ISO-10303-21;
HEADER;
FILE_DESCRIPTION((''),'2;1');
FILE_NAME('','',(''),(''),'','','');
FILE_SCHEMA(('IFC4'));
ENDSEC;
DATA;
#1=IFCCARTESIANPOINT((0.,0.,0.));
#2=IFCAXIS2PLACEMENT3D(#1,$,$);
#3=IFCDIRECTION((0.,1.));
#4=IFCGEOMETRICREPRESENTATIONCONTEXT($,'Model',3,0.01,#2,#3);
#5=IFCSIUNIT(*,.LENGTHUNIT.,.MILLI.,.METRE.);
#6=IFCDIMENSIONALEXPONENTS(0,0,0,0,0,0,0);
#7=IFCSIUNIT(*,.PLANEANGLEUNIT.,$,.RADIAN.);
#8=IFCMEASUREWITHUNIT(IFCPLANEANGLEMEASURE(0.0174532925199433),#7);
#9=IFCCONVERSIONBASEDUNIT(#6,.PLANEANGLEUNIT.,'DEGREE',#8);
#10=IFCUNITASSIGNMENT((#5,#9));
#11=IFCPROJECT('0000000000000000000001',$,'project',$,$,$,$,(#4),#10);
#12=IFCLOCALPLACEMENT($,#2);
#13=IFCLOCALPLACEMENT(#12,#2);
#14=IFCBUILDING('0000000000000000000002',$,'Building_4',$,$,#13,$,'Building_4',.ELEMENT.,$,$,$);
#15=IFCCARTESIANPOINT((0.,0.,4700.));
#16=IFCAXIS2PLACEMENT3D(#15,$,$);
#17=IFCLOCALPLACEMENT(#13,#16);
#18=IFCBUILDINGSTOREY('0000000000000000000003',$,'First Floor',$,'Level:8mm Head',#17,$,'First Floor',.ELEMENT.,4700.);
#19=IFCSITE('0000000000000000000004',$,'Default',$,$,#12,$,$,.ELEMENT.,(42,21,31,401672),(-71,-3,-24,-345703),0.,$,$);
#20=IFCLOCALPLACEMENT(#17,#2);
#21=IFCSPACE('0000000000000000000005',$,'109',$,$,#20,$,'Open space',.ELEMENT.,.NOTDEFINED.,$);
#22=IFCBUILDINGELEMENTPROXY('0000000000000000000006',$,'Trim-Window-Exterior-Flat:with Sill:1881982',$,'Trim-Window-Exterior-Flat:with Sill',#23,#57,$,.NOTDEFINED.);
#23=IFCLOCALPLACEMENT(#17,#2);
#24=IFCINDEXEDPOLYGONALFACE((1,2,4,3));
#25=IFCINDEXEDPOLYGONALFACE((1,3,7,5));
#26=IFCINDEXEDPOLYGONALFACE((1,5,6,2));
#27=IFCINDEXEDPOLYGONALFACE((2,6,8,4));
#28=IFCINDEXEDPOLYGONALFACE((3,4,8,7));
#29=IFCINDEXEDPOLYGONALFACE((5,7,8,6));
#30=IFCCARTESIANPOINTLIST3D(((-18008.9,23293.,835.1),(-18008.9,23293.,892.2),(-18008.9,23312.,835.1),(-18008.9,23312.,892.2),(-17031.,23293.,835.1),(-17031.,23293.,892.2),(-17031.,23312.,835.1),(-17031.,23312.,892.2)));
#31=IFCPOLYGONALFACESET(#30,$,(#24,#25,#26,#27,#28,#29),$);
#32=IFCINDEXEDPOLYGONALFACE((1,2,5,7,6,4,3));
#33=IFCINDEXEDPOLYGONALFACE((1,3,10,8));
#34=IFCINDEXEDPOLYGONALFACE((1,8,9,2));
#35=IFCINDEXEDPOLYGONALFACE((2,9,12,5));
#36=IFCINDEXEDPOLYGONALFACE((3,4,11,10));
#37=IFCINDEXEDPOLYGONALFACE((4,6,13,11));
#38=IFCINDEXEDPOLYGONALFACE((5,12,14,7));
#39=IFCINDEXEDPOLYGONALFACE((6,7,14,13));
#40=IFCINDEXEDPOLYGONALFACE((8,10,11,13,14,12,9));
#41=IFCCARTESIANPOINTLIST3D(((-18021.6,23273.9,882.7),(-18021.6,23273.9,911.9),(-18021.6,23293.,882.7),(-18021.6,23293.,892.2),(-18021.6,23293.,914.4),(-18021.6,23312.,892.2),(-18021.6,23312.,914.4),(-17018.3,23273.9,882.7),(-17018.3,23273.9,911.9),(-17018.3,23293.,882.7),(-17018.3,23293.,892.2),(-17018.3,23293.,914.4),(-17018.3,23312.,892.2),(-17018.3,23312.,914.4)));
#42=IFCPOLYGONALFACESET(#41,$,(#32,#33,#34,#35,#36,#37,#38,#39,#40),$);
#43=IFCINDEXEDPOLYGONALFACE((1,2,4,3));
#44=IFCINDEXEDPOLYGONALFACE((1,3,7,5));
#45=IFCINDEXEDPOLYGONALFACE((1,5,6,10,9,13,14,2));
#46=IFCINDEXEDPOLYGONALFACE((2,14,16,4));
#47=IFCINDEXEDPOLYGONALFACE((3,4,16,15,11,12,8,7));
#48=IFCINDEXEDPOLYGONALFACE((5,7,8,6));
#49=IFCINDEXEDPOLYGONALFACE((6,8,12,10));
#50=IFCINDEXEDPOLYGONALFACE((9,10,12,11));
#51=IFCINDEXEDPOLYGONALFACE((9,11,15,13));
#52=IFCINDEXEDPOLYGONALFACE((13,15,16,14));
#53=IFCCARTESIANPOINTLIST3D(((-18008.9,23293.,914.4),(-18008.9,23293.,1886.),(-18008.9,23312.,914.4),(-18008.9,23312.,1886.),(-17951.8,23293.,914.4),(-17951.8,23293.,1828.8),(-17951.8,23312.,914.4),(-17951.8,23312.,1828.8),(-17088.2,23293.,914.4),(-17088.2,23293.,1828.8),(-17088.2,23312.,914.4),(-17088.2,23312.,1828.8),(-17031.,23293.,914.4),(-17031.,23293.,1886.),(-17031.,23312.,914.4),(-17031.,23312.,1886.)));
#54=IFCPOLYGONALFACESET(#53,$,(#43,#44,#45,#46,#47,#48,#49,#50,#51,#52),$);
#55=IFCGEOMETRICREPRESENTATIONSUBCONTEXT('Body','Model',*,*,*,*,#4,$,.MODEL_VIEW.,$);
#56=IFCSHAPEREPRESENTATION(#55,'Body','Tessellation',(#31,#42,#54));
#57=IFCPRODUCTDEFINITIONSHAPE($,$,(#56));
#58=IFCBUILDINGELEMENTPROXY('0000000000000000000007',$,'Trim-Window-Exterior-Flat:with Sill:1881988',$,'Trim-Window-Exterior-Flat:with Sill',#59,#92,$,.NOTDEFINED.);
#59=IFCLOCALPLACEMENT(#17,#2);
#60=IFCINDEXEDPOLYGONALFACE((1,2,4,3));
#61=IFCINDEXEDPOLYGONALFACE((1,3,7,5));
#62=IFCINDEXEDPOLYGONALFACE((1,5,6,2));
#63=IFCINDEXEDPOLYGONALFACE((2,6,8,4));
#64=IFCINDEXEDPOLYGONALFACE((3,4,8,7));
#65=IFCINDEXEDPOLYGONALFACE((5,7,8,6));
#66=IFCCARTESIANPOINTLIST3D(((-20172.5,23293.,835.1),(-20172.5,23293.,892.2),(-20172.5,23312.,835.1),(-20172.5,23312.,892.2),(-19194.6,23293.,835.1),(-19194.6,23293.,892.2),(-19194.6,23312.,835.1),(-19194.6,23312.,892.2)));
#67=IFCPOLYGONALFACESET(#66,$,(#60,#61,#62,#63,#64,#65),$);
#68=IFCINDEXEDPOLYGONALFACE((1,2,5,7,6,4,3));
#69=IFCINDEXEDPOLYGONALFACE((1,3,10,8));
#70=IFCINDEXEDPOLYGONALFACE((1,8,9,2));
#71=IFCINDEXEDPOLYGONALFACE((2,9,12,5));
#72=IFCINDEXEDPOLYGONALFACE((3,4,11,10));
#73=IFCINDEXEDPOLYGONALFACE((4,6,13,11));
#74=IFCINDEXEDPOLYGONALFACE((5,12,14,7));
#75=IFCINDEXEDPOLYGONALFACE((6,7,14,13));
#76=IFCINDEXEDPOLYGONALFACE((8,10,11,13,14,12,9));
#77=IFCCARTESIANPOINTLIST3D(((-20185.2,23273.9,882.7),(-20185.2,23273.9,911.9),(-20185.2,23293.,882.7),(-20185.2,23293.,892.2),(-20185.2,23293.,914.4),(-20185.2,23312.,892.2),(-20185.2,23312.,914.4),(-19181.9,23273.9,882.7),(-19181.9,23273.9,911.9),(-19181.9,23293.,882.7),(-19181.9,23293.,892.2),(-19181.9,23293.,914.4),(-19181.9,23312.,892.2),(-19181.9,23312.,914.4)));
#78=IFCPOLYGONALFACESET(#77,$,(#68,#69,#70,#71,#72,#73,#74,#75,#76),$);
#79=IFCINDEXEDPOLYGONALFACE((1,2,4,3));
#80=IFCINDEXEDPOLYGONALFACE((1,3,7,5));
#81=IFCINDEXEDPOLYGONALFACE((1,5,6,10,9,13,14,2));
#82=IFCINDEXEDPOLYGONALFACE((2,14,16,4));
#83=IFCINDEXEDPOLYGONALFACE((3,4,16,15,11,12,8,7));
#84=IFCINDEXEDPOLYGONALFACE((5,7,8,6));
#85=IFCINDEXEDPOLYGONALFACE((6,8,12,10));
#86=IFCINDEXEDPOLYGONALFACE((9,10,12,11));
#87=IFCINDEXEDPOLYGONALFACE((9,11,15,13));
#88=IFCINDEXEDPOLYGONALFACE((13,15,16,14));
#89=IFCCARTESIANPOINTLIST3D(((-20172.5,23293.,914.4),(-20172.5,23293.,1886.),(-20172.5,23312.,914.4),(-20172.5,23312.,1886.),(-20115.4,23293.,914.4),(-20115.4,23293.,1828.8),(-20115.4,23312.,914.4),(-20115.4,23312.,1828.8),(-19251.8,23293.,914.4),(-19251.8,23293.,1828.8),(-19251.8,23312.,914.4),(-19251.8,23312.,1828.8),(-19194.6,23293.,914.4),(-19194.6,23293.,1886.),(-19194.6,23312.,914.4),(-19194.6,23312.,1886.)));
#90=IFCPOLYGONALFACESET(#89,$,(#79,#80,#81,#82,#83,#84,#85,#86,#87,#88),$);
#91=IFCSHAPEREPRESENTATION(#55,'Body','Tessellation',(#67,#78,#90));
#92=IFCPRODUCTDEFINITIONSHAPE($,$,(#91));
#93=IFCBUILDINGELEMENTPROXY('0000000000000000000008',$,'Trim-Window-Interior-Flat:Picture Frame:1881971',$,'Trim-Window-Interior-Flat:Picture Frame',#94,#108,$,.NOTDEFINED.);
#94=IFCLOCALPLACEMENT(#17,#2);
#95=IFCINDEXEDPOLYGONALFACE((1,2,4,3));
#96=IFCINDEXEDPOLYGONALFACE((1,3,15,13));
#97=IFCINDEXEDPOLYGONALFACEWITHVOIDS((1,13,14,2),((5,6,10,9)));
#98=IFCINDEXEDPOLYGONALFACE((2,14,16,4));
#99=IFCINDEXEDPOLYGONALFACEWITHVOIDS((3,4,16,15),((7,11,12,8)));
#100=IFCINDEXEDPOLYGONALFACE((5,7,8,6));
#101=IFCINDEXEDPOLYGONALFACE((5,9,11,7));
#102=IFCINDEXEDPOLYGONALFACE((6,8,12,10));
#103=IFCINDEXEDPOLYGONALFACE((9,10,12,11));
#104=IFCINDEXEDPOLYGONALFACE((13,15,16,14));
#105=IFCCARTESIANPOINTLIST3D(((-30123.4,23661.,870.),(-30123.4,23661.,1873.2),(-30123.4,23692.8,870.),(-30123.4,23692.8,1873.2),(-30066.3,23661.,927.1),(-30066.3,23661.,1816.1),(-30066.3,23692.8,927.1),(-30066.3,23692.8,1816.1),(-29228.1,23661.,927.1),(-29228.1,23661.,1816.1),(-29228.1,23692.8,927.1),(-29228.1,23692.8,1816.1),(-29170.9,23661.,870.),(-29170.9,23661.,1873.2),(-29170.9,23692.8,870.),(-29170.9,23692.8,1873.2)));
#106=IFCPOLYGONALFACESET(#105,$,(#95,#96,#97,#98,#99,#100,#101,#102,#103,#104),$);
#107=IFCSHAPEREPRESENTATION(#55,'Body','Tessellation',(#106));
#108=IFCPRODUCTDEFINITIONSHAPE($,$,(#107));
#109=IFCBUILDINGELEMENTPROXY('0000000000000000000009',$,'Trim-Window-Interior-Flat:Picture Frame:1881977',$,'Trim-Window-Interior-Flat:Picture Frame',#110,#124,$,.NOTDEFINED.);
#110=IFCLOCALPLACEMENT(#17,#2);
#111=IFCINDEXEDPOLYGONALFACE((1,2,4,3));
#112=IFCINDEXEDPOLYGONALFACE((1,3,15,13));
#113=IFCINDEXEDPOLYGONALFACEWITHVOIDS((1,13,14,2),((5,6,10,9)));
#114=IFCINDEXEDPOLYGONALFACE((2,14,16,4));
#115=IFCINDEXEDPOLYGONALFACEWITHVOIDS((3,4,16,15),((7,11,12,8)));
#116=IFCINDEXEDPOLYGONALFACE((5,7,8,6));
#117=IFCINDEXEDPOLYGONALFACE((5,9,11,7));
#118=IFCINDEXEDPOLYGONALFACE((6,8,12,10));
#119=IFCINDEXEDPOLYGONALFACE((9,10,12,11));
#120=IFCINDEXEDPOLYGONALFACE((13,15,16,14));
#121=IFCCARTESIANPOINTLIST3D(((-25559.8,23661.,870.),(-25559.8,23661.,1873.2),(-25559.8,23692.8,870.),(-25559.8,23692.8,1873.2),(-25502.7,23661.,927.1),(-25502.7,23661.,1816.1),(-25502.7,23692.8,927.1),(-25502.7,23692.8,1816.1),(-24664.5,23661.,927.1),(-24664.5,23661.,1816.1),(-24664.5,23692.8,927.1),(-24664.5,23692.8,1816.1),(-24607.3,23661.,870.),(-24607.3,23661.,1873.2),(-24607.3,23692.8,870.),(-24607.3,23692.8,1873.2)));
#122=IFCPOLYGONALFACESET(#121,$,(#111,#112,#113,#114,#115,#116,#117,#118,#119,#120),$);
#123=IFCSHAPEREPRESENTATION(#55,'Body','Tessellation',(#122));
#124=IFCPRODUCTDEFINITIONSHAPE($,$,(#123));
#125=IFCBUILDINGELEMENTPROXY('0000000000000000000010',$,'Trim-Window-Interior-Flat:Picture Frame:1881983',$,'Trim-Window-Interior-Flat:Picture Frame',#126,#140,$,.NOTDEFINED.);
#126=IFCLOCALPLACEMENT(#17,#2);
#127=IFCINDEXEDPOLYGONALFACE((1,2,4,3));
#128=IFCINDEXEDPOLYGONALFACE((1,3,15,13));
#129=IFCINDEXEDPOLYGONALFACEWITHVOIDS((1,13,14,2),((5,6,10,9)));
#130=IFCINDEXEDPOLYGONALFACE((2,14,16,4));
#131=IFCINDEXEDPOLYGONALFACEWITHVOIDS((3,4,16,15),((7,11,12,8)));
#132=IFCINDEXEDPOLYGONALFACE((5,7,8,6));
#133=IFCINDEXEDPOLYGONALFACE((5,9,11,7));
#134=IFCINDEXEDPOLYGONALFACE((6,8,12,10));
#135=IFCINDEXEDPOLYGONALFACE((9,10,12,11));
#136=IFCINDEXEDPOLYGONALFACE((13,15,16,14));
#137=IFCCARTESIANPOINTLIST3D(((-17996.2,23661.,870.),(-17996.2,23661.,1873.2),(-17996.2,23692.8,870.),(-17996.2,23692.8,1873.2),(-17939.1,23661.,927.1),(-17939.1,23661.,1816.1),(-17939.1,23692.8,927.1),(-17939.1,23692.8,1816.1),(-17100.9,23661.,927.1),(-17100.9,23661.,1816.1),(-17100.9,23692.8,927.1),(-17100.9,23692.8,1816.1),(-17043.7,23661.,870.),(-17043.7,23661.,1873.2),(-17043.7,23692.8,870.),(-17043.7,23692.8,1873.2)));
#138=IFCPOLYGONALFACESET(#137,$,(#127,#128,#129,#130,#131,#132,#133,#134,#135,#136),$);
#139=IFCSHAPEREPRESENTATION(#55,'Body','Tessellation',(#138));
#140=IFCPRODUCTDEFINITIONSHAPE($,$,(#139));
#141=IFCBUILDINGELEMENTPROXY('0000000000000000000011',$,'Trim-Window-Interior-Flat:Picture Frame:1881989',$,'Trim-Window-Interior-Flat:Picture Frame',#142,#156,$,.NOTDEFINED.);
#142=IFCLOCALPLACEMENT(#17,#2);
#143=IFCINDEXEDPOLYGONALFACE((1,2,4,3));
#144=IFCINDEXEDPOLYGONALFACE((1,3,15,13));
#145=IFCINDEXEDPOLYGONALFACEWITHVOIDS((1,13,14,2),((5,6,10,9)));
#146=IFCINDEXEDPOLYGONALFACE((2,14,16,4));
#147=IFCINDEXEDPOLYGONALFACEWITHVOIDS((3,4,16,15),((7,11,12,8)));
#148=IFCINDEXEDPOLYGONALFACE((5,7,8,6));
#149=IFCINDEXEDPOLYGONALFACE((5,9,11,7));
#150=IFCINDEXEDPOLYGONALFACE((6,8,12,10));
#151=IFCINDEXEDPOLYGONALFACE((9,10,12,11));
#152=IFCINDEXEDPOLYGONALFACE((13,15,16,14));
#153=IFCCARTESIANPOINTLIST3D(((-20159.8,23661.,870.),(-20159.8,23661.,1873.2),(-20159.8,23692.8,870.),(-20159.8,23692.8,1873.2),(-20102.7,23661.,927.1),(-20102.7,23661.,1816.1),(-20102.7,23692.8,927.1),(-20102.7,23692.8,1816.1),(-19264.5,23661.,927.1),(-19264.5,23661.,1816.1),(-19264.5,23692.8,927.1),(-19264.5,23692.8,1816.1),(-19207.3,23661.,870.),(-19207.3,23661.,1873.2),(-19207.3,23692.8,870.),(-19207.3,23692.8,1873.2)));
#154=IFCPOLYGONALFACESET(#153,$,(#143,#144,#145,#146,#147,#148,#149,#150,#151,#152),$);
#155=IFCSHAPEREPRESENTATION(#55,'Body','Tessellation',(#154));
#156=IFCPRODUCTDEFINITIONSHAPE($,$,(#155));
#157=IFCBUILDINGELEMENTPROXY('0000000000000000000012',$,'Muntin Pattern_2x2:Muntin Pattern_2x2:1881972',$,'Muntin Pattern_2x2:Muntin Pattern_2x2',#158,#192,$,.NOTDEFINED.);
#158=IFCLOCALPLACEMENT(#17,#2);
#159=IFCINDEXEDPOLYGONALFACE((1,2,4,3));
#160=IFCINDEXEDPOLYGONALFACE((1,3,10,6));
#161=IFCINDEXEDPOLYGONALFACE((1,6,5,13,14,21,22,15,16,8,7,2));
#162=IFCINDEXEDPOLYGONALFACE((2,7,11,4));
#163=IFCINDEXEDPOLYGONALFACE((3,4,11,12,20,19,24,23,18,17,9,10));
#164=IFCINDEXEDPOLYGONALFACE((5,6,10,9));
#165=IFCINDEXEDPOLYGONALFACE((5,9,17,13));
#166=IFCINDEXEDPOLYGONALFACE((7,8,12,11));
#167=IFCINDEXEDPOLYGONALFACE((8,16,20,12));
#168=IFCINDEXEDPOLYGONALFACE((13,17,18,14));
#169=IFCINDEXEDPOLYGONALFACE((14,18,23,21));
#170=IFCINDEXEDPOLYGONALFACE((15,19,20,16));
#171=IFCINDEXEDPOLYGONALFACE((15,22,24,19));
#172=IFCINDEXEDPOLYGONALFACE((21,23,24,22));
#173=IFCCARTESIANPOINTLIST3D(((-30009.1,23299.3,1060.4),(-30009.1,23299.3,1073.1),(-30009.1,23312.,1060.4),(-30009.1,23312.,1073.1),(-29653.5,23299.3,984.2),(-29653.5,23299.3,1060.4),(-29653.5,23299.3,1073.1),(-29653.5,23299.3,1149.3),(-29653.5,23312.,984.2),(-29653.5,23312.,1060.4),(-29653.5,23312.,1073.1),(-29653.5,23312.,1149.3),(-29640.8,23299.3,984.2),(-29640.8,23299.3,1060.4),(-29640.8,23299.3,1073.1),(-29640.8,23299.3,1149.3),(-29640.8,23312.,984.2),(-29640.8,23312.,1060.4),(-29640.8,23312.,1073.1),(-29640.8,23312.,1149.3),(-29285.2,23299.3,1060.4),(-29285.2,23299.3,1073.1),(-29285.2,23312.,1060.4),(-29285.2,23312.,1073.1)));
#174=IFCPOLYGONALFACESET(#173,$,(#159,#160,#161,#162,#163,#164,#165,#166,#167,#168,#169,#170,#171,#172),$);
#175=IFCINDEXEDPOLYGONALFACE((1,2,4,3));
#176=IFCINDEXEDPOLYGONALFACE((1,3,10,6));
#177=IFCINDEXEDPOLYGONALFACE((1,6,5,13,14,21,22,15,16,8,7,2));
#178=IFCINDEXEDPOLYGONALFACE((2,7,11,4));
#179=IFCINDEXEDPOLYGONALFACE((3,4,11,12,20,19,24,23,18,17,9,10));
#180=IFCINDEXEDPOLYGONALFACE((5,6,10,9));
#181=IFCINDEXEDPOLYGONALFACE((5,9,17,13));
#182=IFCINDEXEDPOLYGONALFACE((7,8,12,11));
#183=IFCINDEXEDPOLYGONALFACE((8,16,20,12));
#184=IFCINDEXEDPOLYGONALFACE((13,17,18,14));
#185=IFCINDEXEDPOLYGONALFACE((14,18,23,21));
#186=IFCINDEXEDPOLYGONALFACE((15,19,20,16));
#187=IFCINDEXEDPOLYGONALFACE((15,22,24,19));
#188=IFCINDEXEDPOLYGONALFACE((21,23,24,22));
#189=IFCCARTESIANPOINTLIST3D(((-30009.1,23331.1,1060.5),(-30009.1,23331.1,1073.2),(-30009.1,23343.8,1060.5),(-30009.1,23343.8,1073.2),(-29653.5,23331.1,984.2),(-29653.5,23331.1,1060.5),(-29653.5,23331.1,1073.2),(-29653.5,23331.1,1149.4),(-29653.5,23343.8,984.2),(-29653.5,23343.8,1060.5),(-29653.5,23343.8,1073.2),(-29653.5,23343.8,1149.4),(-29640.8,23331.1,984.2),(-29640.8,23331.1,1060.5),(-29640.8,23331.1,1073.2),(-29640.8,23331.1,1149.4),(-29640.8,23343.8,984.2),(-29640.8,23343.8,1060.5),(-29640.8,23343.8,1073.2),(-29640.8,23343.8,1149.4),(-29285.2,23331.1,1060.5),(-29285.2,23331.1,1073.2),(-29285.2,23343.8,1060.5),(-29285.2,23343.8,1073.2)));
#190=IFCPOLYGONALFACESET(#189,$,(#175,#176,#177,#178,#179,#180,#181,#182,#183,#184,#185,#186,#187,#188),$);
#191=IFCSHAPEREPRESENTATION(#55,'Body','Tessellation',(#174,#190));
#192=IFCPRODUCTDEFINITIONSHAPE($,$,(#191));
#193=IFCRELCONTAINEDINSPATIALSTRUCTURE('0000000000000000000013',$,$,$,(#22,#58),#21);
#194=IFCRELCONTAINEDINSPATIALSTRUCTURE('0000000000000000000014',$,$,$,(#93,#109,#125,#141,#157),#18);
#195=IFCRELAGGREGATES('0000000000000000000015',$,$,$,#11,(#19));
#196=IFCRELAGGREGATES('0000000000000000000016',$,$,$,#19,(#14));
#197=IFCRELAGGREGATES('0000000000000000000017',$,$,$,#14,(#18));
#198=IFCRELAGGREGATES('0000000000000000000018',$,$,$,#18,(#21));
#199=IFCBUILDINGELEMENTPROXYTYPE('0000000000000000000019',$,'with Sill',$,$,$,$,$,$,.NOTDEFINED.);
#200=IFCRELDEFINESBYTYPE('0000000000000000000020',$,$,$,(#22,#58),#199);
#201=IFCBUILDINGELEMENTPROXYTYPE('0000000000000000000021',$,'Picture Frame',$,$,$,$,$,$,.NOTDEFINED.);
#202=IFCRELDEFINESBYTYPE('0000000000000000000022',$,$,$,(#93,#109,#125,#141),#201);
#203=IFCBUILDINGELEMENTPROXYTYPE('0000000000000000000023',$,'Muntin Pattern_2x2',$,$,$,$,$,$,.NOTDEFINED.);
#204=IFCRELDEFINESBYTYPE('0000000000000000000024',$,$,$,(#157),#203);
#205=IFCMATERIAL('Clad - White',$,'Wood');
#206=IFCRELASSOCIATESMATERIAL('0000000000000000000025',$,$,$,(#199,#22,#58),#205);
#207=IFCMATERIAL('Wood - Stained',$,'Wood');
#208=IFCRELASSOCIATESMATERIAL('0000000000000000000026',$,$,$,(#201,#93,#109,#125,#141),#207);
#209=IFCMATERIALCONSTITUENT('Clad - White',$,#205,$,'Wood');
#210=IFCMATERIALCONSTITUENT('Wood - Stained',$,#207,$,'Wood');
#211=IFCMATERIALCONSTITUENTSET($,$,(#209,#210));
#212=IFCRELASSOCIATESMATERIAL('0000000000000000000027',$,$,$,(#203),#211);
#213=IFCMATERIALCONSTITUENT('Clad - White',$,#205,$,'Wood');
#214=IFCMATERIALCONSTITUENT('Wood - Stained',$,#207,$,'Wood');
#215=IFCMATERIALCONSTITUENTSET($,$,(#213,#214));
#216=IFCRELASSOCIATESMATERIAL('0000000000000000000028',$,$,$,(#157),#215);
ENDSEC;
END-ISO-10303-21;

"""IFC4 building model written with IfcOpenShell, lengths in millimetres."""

from ifc_helpers import new_model, entity, si_unit, converted_unit, direction, frame, origin, place, context, subcontext, project, spatial, indexed_curve, outline, extrude, source, transform, mapped, material, constituent, constituent_set, type_object, type_shapes, element, save


model = new_model("IFC4")

# Units and contexts
model_context = context("Model", 3, precision=0.01, world=origin(), true_north=direction((0.0, 1.0)))
body_context = subcontext(model_context, "Body", "Model", "MODEL_VIEW")
ifc_project = project(units=[si_unit("LENGTHUNIT", "METRE", prefix="MILLI"), converted_unit("PLANEANGLEUNIT", "DEGREE", entity("IfcPlaneAngleMeasure", 0.0174532925199433), si_unit("PLANEANGLEUNIT", "RADIAN"), dimensions=[0, 0, 0, 0, 0, 0, 0])], contexts=[model_context])

# Site, building, storey
site_placement = place(None, origin())
site = spatial("IfcSite", under=ifc_project, at=site_placement, Name="Default", CompositionType="ELEMENT", RefLatitude=(42, 21, 31, 401672), RefLongitude=(-71, -3, -24, -345703), RefElevation=0.0)
building_placement = place(site_placement, origin())
building = spatial("IfcBuilding", under=site, at=building_placement, Name="Building_4", LongName="Building_4", CompositionType="ELEMENT")
storey_placement = place(building_placement, frame((0.0, 0.0, 4700.0)))
storey = spatial("IfcBuildingStorey", under=building, at=storey_placement, Name="First Floor", ObjectType="Level:8mm Head", LongName="First Floor", CompositionType="ELEMENT", Elevation=4700.0)

# Shared definitions
ifc_material_1 = material(Name="Clad - White", Category="Wood")
ifc_material_2 = material(Name="Wood - Stained", Category="Wood")

# Shared definitions
building_element_proxy_type_1 = type_object("IfcBuildingElementProxyType", Name="with Sill", PredefinedType="NOTDEFINED", material=ifc_material_1)
shared_shape_1 = source(origin(), body_context, "Body", "SweptSolid", [
    extrude(outline(indexed_curve([(-488.9, -28.6), (488.9, -28.6), (488.9, 28.6), (-488.9, 28.6), (-488.9, -28.6)], self_intersect=False)), frame((0.0, -965.2, 0.0), z_axis=(0.0, 0.0, 1.0), x_axis=(-1.0, 0.0, 0.0)), (0.0, 0.0, 1.0), 19.1),
    extrude(outline(indexed_curve([(-19.0, -16.0), (0.0, -16.0), (0.0, -6.4), (19.0, -6.4), (19.0, 15.8), (0.0, 15.8), (-19.0, 13.3), (-19.0, -16.0)], self_intersect=False)), frame((-501.6, -930.2, 19.0), z_axis=(1.0, 0.0, 0.0), x_axis=(0.0, 0.0, -1.0)), (0.0, 0.0, 1.0), 1003.3),
    extrude(outline(indexed_curve([(-500.1, -488.9), (471.5, -488.9), (471.5, -431.8), (-442.9, -431.8), (-442.9, 431.8), (471.5, 431.8), (471.5, 488.9), (-500.1, 488.9), (-500.1, -488.9)], self_intersect=False)), frame((0.0, -442.9, 0.0), z_axis=(0.0, 0.0, 1.0), x_axis=(0.0, -1.0, 0.0)), (0.0, 0.0, 1.0), 19.1),
])
type_shapes(building_element_proxy_type_1, [shared_shape_1])

# Shared definitions
space_1_placement = place(storey_placement, origin())
space_1 = spatial("IfcSpace", under=storey, at=space_1_placement, Name="109", LongName="Open space", CompositionType="ELEMENT", PredefinedType="NOTDEFINED")

# Building element proxies
for number, where, z_axis, x_axis, name in (
    (1, (-17520.0, 23312.0, 1828.8), (0.0, -1.0, 0.0), (1.0, 0.0, 0.0), "Trim-Window-Exterior-Flat:with Sill:1881982"),
    (2, (-19683.6, 23312.0, 1828.8), (0.0, -1.0, 0.0), (1.0, 0.0, 0.0), "Trim-Window-Exterior-Flat:with Sill:1881988"),
):
    element("IfcBuildingElementProxy", number, at=place(space_1_placement, frame(where, z_axis=z_axis, x_axis=x_axis)), inside=space_1, type_object=building_element_proxy_type_1, material=ifc_material_1, Name=name, ObjectType="Trim-Window-Exterior-Flat:with Sill", PredefinedType="NOTDEFINED", context=body_context, shape_type="MappedRepresentation", body=[
        mapped(shared_shape_1, transform((0.0, 0.0, 0.0), scale=1.0)),
    ])
building_element_proxy_type_2 = type_object("IfcBuildingElementProxyType", Name="Picture Frame", PredefinedType="NOTDEFINED", material=ifc_material_2)
shared_shape_2 = source(origin(), body_context, "Body", "SweptSolid", [
    extrude(outline(indexed_curve([(-476.2, -501.6), (476.2, -501.6), (476.2, 501.6), (-476.2, 501.6), (-476.2, -501.6)], self_intersect=False), holes=[indexed_curve([(-419.1, -444.5), (-419.1, 444.5), (419.1, 444.5), (419.1, -444.5), (-419.1, -444.5)], self_intersect=False)]), frame((0.0, -457.2, 0.0), z_axis=(0.0, 0.0, 1.0), x_axis=(-1.0, 0.0, 0.0)), (0.0, 0.0, 1.0), 31.8),
])
type_shapes(building_element_proxy_type_2, [shared_shape_2])
for number, where, z_axis, x_axis, name in (
    (3, (-29647.2, 23661.0, 1828.8), (0.0, 1.0, 0.0), (-1.0, 0.0, 0.0), "Trim-Window-Interior-Flat:Picture Frame:1881971"),
    (4, (-25083.6, 23661.0, 1828.8), (0.0, 1.0, 0.0), (-1.0, 0.0, 0.0), "Trim-Window-Interior-Flat:Picture Frame:1881977"),
    (5, (-17520.0, 23661.0, 1828.8), (0.0, 1.0, 0.0), (-1.0, 0.0, 0.0), "Trim-Window-Interior-Flat:Picture Frame:1881983"),
    (6, (-19683.6, 23661.0, 1828.8), (0.0, 1.0, 0.0), (-1.0, 0.0, 0.0), "Trim-Window-Interior-Flat:Picture Frame:1881989"),
):
    element("IfcBuildingElementProxy", number, at=place(storey_placement, frame(where, z_axis=z_axis, x_axis=x_axis)), inside=storey, type_object=building_element_proxy_type_2, material=ifc_material_2, Name=name, ObjectType="Trim-Window-Interior-Flat:Picture Frame", PredefinedType="NOTDEFINED", context=body_context, shape_type="MappedRepresentation", body=[
        mapped(shared_shape_2, transform((0.0, 0.0, 0.0), scale=1.0)),
    ])
ifc_constituent_1 = constituent(ifc_material_1, Name="Clad - White", Category="Wood")
ifc_constituent_2 = constituent(ifc_material_2, Name="Wood - Stained", Category="Wood")
ifc_constituent_set_1 = constituent_set(constituents=[ifc_constituent_1, ifc_constituent_2])
ifc_constituent_3 = constituent(ifc_material_1, Name="Clad - White", Category="Wood")
ifc_constituent_4 = constituent(ifc_material_2, Name="Wood - Stained", Category="Wood")
ifc_constituent_set_2 = constituent_set(constituents=[ifc_constituent_3, ifc_constituent_4])
building_element_proxy_type_3 = type_object("IfcBuildingElementProxyType", Name="Muntin Pattern_2x2", PredefinedType="NOTDEFINED", material=ifc_constituent_set_2)
shared_shape_3 = source(origin(), body_context, "Body", "SweptSolid", [
    extrude(outline(indexed_curve([(6.4, -6.4), (82.5, -6.4), (82.5, 6.3), (6.4, 6.3), (6.4, 362.0), (-6.3, 362.0), (-6.3, 6.3), (-82.6, 6.3), (-82.6, -6.4), (-6.3, -6.4), (-6.3, -361.9), (6.4, -361.9), (6.4, -6.4)], self_intersect=False)), frame((0.0, -22.2, 82.5), z_axis=(0.0, 1.0, 0.0), x_axis=(0.0, 0.0, 1.0)), (0.0, 0.0, 1.0), 12.7),
    extrude(outline(indexed_curve([(6.4, -6.4), (82.6, -6.4), (82.6, 6.3), (6.4, 6.3), (6.4, 362.0), (-6.3, 362.0), (-6.3, 6.3), (-82.6, 6.3), (-82.6, -6.4), (-6.3, -6.4), (-6.3, -361.9), (6.4, -361.9), (6.4, -6.4)], self_intersect=False)), frame((0.0, 9.5, 82.6), z_axis=(0.0, 1.0, 0.0), x_axis=(0.0, 0.0, 1.0)), (0.0, 0.0, 1.0), 12.7),
])
type_shapes(building_element_proxy_type_3, [shared_shape_3])
proxy_1_placement = place(storey_placement, frame((-29647.2, 23321.5, 984.2)))
element("IfcBuildingElementProxy", 7, at=proxy_1_placement, inside=storey, type_object=building_element_proxy_type_3, material=ifc_constituent_set_1, Name="Muntin Pattern_2x2:Muntin Pattern_2x2:1881972", ObjectType="Muntin Pattern_2x2:Muntin Pattern_2x2", PredefinedType="NOTDEFINED", context=body_context, shape_type="MappedRepresentation", body=[
    mapped(shared_shape_3, transform((0.0, 0.0, 0.0), scale=1.0)),
])

save(model, "model.ifc")
